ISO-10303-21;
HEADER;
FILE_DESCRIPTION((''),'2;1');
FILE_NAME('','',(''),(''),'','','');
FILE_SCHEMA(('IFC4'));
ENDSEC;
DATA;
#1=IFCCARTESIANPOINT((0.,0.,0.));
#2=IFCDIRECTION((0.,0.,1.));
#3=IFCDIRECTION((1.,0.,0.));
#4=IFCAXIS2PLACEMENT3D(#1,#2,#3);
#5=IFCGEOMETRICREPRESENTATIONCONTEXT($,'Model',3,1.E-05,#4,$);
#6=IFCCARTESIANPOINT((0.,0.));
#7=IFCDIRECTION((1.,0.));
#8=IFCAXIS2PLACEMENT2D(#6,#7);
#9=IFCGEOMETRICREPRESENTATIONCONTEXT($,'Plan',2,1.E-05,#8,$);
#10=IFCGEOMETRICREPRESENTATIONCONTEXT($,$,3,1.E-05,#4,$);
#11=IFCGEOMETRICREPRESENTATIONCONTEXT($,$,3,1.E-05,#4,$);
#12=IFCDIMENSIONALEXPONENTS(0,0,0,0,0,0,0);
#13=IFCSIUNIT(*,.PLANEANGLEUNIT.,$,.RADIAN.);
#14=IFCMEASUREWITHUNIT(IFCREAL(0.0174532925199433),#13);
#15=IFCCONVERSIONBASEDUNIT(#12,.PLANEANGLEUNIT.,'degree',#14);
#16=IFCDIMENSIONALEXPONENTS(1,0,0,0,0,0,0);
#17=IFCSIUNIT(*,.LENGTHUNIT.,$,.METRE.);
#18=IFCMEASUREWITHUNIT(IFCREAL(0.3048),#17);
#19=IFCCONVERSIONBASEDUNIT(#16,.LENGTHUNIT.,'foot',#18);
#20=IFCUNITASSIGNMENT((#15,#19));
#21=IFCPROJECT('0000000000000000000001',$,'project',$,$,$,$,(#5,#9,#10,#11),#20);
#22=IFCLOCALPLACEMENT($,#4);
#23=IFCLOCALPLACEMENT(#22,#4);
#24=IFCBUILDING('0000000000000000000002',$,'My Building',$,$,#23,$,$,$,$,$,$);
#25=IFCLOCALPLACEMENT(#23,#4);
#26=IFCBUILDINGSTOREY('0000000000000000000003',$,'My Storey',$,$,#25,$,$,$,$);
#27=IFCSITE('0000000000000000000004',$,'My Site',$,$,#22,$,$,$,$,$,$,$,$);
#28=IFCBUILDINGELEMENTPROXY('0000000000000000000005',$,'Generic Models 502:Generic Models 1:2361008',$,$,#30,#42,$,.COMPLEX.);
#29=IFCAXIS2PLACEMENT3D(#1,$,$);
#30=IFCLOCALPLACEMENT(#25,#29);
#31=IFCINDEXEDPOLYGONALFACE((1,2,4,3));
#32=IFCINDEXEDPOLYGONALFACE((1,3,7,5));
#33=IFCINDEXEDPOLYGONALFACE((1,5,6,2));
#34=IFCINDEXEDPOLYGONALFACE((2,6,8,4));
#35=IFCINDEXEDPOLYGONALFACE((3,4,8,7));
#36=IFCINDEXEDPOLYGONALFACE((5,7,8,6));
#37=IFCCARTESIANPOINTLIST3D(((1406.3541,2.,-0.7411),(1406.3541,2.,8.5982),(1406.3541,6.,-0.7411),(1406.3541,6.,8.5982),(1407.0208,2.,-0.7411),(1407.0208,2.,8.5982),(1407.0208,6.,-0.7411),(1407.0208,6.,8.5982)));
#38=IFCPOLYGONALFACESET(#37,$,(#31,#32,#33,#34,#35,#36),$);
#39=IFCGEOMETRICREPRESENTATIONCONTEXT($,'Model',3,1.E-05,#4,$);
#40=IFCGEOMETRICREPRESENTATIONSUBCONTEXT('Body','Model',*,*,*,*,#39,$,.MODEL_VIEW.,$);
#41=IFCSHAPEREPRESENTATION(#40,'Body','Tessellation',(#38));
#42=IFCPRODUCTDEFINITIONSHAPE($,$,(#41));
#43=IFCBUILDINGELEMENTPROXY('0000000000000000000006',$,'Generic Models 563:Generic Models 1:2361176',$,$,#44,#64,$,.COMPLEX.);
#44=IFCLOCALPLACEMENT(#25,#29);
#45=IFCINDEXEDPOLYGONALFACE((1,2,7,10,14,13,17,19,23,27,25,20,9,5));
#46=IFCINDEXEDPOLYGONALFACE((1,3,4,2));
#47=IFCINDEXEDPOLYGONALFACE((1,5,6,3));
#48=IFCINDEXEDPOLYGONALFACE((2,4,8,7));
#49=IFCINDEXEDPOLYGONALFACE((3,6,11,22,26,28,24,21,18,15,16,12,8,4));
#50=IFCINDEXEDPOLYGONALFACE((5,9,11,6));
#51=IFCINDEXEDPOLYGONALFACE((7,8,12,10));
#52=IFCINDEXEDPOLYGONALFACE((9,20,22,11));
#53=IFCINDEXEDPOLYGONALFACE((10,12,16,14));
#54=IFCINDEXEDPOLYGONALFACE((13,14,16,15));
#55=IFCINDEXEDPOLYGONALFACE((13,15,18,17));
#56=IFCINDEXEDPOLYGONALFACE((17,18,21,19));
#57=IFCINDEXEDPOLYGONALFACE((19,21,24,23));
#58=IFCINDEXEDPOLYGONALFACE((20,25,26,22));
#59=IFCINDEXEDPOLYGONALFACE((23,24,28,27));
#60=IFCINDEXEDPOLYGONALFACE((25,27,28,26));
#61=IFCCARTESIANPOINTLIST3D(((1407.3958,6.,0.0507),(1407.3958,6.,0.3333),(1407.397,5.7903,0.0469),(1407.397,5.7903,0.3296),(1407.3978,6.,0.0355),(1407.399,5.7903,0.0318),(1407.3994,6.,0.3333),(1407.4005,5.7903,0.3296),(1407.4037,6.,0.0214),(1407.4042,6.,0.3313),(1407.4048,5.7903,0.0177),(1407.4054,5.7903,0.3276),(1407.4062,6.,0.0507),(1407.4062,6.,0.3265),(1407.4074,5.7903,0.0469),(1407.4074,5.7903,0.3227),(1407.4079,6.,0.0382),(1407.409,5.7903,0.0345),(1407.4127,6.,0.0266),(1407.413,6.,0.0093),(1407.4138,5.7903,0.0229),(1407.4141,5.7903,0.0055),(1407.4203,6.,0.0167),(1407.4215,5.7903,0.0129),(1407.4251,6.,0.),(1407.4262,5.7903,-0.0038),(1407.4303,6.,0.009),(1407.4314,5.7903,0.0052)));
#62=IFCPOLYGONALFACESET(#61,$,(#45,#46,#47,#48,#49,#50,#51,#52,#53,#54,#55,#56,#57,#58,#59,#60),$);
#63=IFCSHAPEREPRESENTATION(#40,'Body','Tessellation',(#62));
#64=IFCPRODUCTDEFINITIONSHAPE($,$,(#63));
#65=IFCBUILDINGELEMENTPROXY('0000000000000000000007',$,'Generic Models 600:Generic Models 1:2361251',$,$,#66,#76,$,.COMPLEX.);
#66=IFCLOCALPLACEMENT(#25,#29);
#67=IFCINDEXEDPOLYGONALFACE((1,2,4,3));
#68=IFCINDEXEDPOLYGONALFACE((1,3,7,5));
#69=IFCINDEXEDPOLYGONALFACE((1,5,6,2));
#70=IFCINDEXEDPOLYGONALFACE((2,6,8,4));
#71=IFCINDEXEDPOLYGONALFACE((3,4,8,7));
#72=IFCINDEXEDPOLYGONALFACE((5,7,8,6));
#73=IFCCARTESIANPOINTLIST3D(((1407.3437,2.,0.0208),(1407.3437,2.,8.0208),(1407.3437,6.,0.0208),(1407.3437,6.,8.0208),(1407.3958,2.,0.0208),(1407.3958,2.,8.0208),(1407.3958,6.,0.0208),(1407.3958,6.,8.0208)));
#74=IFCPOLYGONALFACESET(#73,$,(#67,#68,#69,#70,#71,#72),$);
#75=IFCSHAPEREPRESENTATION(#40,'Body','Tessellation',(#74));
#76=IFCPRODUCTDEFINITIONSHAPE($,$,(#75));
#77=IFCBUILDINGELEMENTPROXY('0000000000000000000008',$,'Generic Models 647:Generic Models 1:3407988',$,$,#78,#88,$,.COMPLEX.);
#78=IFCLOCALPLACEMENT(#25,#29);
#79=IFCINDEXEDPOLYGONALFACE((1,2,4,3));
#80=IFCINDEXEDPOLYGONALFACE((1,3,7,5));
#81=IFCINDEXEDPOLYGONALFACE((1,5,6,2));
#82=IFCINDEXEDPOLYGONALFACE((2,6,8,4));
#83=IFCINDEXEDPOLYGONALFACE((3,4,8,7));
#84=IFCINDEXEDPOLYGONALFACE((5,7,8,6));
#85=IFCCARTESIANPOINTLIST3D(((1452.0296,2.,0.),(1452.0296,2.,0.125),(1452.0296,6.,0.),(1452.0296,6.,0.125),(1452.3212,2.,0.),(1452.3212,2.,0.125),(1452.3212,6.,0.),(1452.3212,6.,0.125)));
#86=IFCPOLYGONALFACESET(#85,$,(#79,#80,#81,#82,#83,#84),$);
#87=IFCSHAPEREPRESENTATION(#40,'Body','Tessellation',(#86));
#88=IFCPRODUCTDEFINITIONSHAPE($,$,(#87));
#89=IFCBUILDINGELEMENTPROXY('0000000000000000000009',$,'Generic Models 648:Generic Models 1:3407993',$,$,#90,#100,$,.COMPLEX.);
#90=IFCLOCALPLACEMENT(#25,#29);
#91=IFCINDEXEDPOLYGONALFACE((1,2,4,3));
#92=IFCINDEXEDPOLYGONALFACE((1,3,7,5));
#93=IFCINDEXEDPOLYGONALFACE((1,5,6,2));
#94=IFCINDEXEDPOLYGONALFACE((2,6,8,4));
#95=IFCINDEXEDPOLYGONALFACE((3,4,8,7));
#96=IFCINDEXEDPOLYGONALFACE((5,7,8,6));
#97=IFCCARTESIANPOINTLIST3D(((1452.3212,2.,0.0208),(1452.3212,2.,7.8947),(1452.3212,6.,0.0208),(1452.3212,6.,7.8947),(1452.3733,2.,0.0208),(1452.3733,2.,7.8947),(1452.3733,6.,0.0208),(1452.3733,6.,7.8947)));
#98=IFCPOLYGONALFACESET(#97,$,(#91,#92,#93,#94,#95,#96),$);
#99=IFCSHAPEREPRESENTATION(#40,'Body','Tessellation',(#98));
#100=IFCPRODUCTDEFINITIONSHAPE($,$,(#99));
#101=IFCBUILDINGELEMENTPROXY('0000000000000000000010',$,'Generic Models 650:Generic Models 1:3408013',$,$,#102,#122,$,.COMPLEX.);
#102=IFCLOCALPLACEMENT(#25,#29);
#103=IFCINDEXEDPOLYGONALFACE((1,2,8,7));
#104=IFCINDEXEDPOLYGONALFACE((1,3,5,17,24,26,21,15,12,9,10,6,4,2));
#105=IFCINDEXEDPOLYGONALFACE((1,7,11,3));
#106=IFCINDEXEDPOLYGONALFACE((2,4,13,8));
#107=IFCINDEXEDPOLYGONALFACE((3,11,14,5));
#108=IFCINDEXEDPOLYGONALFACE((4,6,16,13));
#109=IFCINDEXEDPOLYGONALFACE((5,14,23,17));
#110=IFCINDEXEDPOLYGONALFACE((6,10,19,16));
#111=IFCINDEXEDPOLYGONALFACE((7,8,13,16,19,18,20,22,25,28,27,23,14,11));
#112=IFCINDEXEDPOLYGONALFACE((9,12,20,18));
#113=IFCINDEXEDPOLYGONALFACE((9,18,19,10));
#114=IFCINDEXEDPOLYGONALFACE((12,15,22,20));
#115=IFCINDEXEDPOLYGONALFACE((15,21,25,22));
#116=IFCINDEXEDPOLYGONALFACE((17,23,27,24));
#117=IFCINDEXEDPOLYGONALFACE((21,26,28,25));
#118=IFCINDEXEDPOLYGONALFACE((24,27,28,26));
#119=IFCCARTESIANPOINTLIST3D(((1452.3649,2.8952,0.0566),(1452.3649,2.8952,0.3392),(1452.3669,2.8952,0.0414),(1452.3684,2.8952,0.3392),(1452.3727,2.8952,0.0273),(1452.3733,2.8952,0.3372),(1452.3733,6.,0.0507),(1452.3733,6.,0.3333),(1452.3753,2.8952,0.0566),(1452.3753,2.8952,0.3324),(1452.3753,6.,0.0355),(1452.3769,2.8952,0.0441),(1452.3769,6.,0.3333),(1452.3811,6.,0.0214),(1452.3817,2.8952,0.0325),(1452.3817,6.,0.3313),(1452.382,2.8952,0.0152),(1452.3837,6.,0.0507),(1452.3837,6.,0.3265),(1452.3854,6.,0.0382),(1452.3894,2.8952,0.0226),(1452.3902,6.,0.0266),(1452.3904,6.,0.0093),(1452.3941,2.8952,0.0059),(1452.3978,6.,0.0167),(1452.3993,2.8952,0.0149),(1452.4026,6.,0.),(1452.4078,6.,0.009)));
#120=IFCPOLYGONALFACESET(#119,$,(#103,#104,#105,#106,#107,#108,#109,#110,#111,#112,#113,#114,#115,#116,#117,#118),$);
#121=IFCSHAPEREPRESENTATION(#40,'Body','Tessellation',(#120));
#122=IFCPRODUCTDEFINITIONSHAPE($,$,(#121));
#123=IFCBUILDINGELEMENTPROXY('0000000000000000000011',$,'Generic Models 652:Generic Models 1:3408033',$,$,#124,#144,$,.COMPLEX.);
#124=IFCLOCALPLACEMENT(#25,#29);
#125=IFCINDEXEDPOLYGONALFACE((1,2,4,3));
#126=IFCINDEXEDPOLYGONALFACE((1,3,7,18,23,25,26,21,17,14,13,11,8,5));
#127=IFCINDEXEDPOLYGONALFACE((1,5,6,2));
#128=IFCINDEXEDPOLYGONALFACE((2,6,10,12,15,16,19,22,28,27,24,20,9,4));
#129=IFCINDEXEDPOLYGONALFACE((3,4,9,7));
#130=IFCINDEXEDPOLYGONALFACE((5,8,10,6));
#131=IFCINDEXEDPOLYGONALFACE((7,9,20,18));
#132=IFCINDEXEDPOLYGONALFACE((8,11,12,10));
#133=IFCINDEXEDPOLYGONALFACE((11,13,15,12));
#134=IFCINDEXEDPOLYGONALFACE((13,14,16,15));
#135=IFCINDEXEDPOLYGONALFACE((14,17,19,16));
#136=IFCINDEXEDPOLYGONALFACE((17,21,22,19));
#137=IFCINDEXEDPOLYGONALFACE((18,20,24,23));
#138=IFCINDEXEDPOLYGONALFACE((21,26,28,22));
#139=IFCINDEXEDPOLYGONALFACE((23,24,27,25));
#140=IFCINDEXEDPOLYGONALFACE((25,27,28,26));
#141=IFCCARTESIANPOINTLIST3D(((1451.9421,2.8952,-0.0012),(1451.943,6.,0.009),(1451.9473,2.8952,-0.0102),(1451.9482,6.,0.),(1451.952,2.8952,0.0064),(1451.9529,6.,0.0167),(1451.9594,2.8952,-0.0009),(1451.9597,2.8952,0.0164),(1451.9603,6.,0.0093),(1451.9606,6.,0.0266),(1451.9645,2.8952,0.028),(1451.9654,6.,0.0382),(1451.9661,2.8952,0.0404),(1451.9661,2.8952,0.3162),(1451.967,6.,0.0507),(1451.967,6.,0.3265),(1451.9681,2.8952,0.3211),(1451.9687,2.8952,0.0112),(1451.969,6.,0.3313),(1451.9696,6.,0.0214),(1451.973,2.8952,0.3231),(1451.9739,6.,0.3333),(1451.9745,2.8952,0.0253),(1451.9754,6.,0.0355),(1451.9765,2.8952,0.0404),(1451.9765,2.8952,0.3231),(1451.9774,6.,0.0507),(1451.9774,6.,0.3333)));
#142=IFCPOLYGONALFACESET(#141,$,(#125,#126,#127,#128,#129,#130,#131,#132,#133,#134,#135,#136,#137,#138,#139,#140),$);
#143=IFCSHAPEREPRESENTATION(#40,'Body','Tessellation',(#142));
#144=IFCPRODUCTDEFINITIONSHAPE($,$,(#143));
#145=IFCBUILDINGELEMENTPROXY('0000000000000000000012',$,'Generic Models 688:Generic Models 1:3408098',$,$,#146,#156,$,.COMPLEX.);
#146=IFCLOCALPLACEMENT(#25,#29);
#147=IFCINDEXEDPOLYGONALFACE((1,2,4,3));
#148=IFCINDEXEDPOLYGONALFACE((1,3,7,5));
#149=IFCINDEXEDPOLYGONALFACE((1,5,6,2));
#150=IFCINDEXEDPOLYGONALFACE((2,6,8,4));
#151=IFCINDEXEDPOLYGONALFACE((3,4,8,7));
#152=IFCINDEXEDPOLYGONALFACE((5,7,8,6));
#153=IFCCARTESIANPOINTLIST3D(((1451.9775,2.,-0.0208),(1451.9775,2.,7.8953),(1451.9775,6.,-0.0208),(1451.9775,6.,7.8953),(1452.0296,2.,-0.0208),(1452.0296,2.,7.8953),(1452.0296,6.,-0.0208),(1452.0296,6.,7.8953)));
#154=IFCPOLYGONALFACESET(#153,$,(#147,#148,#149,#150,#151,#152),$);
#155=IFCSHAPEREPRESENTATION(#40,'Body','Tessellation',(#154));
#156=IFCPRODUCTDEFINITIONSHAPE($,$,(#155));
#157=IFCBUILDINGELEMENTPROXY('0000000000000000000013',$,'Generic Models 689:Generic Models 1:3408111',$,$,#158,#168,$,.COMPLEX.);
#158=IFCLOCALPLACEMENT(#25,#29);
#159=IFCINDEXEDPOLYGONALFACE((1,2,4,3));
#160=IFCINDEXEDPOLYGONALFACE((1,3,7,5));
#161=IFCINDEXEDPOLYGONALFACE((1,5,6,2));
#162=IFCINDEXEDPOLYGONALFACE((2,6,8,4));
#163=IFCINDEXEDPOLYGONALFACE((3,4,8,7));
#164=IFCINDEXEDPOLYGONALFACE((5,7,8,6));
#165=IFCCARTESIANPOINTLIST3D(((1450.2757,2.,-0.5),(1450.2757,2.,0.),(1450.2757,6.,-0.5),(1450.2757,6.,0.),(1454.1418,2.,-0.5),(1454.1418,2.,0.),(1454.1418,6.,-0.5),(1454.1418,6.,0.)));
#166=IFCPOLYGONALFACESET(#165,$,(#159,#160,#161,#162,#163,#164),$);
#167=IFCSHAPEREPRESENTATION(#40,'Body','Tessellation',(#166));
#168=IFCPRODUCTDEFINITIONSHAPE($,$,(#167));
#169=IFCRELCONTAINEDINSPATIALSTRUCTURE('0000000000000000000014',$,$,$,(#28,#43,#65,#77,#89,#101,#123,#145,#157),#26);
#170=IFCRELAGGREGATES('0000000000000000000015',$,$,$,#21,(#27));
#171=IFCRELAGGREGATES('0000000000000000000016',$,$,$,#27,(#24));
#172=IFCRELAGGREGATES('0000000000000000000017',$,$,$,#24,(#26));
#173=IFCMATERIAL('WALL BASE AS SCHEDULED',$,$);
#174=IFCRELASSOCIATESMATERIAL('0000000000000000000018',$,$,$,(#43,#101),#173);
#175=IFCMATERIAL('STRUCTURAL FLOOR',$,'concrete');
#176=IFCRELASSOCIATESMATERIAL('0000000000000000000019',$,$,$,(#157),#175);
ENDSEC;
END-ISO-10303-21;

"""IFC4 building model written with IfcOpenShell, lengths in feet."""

from ifc_helpers import new_model, entity, si_unit, converted_unit, frame, origin_with_axes, origin_2d_with_axis, place, context, subcontext, project, spatial, polyline, line, indexed_curve, outline, extrude, material, element, save


model = new_model("IFC4")

# Units and contexts
model_context_1 = context("Model", 3, precision=1e-05, world=origin_with_axes())
plan_context = context("Plan", 2, precision=1e-05, world=origin_2d_with_axis())
model_context_2 = context("Model", 3, precision=1e-05, world=origin_with_axes())
context_of_model_1 = context(None, 3, precision=1e-05, world=origin_with_axes())
context_of_model_2 = context(None, 3, precision=1e-05, world=origin_with_axes())
body_context = subcontext(model_context_2, "Body", "Model", "MODEL_VIEW")
ifc_project = project(units=[converted_unit("PLANEANGLEUNIT", "degree", entity("IfcReal", 0.0174532925199433), si_unit("PLANEANGLEUNIT", "RADIAN"), dimensions=[0, 0, 0, 0, 0, 0, 0]), converted_unit("LENGTHUNIT", "foot", entity("IfcReal", 0.3048), si_unit("LENGTHUNIT", "METRE"), dimensions=[1, 0, 0, 0, 0, 0, 0])], contexts=[model_context_1, plan_context, context_of_model_1, context_of_model_2])

# Site, building, storey
site_placement = place(None, origin_with_axes())
site = spatial("IfcSite", under=ifc_project, at=site_placement, Name="My Site")
building_placement = place(site_placement, origin_with_axes())
building = spatial("IfcBuilding", under=site, at=building_placement, Name="My Building")
storey_placement = place(building_placement, origin_with_axes())
storey = spatial("IfcBuildingStorey", under=building, at=storey_placement, Name="My Storey")

# Building element proxies
proxy_1_placement = place(storey_placement, frame((1406.3541, 6.0, -0.7411), z_axis=(0.0, -1.0, 0.0), x_axis=(0.0, 0.0, 1.0)))
element("IfcBuildingElementProxy", 1, at=proxy_1_placement, inside=storey, Name="Generic Models 502:Generic Models 1:2361008", PredefinedType="COMPLEX", context=body_context, shape_type="SweptSolid", body=[
    extrude(outline(indexed_curve([(-0.3333, -4.6697), (0.3333, -4.6697), (0.3333, 4.6697), (-0.3333, 4.6697)], segments=[line(4, 1), line(1, 2), line(2, 3), line(3, 4)], self_intersect=False)), frame((4.6697, -0.3333, 0.0), z_axis=(0.0, 0.0, -1.0), x_axis=(0.0, 1.0, 0.0)), (0.0, 0.0, -1.0), 4.0),
])
ifc_material_1 = material(Name="WALL BASE AS SCHEDULED")
proxy_2_placement = place(storey_placement, frame((1407.3958, 6.0, 0.0), z_axis=(0.0, -1.0, 0.0), x_axis=(0.0, 0.0, 1.0)))
element("IfcBuildingElementProxy", 2, at=proxy_2_placement, inside=storey, material=ifc_material_1, Name="Generic Models 563:Generic Models 1:2361176", PredefinedType="COMPLEX", context=body_context, shape_type="SweptSolid", body=[
    extrude(outline(polyline([(0.0971, 0.0), (0.1059, -0.009), (0.1142, -0.0027), (0.1035, 0.0082), (0.0904, 0.016), (0.0756, 0.02), (0.0603, 0.0202), (-0.2202, -0.0144), (-0.2197, -0.0179), (-0.2172, -0.0225), (-0.2121, -0.0239), (0.0616, 0.0098), (0.0742, 0.0097), (0.0863, 0.0064), (0.0971, 0.0)])), frame((0.113, -0.0126, 0.0), z_axis=(0.0, 0.0, -1.0), x_axis=(-0.992503, -0.12222, 0.0)), (0.01852, -0.003236, -0.999823), 0.2098),
])
proxy_3_placement = place(storey_placement, frame((1407.3437, 6.0, 0.0208), z_axis=(0.0, -1.0, 0.0), x_axis=(0.0, 0.0, 1.0)))
element("IfcBuildingElementProxy", 3, at=proxy_3_placement, inside=storey, Name="Generic Models 600:Generic Models 1:2361251", PredefinedType="COMPLEX", context=body_context, shape_type="SweptSolid", body=[
    extrude(outline(polyline([(-4.0, -0.026), (4.0, -0.026), (4.0, 0.026), (-4.0, 0.026), (-4.0, -0.026)])), frame((4.0, -0.026, 0.0), z_axis=(0.0, 0.0, -1.0), x_axis=(1.0, 0.0, 0.0)), (0.0, 0.0, -1.0), 4.0),
])
proxy_4_placement = place(storey_placement, frame((1452.0296, 6.0, 0.0), z_axis=(0.0, -1.0, 0.0), x_axis=(0.0, 0.0, 1.0)))
element("IfcBuildingElementProxy", 4, at=proxy_4_placement, inside=storey, Name="Generic Models 647:Generic Models 1:3407988", PredefinedType="COMPLEX", context=body_context, shape_type="SweptSolid", body=[
    extrude(outline(polyline([(-0.0625, -0.1458), (0.0625, -0.1458), (0.0625, 0.1458), (-0.0625, 0.1458), (-0.0625, -0.1458)])), frame((0.0625, -0.1458, 0.0), z_axis=(0.0, 0.0, -1.0), x_axis=(1.0, 0.0, 0.0)), (0.0, 0.0, -1.0), 4.0),
])
proxy_5_placement = place(storey_placement, frame((1452.3212, 6.0, 0.0208), z_axis=(0.0, -1.0, 0.0), x_axis=(0.0, 0.0, 1.0)))
element("IfcBuildingElementProxy", 5, at=proxy_5_placement, inside=storey, Name="Generic Models 648:Generic Models 1:3407993", PredefinedType="COMPLEX", context=body_context, shape_type="SweptSolid", body=[
    extrude(outline(polyline([(-3.9369, -0.026), (3.9369, -0.026), (3.9369, 0.026), (-3.9369, 0.026), (-3.9369, -0.026)])), frame((3.9369, -0.026, 0.0), z_axis=(0.0, 0.0, -1.0), x_axis=(1.0, 0.0, 0.0)), (0.0, 0.0, -1.0), 4.0),
])
proxy_6_placement = place(storey_placement, frame((1452.3733, 6.0, 0.0), z_axis=(0.0, -1.0, 0.0), x_axis=(0.0, 0.0, 1.0)))
element("IfcBuildingElementProxy", 6, at=proxy_6_placement, inside=storey, material=ifc_material_1, Name="Generic Models 650:Generic Models 1:3408013", PredefinedType="COMPLEX", context=body_context, shape_type="SweptSolid", body=[
    extrude(outline(polyline([(0.2206, 0.0), (0.2204, 0.0036), (0.2182, 0.0083), (0.2132, 0.01), (-0.0621, -0.0058), (-0.0747, -0.0049), (-0.0865, -0.0007), (-0.0969, 0.0063), (-0.1051, 0.0158), (-0.1138, 0.0101), (-0.1038, -0.0014), (-0.0912, -0.01), (-0.0768, -0.0151), (-0.0615, -0.0162), (0.2206, 0.0)])), frame((0.113, -0.0126, 0.0), z_axis=(0.0, 0.0, -1.0), x_axis=(0.998358, 0.057286, 0.0)), (0.002054, -0.002598, -0.999995), 3.1048),
])
proxy_7_placement = place(storey_placement, frame((1451.943, 6.0, 0.0), z_axis=(0.0, -1.0, 0.0), x_axis=(0.0, 0.0, 1.0)))
element("IfcBuildingElementProxy", 7, at=proxy_7_placement, inside=storey, Name="Generic Models 652:Generic Models 1:3408033", PredefinedType="COMPLEX", context=body_context, shape_type="SweptSolid", body=[
    extrude(outline(polyline([(-0.0624, 0.0022), (0.2134, 0.0022), (0.2183, 0.0042), (0.2203, 0.0091), (0.2203, 0.0126), (-0.0624, 0.0126), (-0.0775, 0.0106), (-0.0916, 0.0048), (-0.1037, -0.0045), (-0.113, -0.0166), (-0.104, -0.0218), (-0.0964, -0.0119), (-0.0864, -0.0042), (-0.0748, 0.0006), (-0.0624, 0.0022)])), frame((0.113, -0.0218, 0.0), z_axis=(0.0, 0.0, -1.0), x_axis=(1.0, 0.0, 0.0)), (-0.003299, -0.000291, -0.999995), 3.1048),
])
proxy_8_placement = place(storey_placement, frame((1451.9775, 6.0, -0.0208), z_axis=(0.0, -1.0, 0.0), x_axis=(0.0, 0.0, 1.0)))
element("IfcBuildingElementProxy", 8, at=proxy_8_placement, inside=storey, Name="Generic Models 688:Generic Models 1:3408098", PredefinedType="COMPLEX", context=body_context, shape_type="SweptSolid", body=[
    extrude(outline(polyline([(-3.9581, -0.026), (3.9581, -0.026), (3.9581, 0.026), (-3.9581, 0.026), (-3.9581, -0.026)])), frame((3.9581, -0.026, 0.0), z_axis=(0.0, 0.0, -1.0), x_axis=(1.0, 0.0, 0.0)), (0.0, 0.0, -1.0), 4.0),
])
ifc_material_2 = material(Name="STRUCTURAL FLOOR", Category="concrete")
proxy_9_placement = place(storey_placement, frame((1450.2757, 6.0, -0.5), z_axis=(0.0, -1.0, 0.0), x_axis=(0.0, 0.0, 1.0)))
element("IfcBuildingElementProxy", 9, at=proxy_9_placement, inside=storey, material=ifc_material_2, Name="Generic Models 689:Generic Models 1:3408111", PredefinedType="COMPLEX", context=body_context, shape_type="SweptSolid", body=[
    extrude(outline(polyline([(-0.25, -1.9331), (0.25, -1.9331), (0.25, 1.9331), (-0.25, 1.9331), (-0.25, -1.9331)])), frame((0.25, -1.9331, 0.0), z_axis=(0.0, 0.0, -1.0), x_axis=(1.0, 0.0, 0.0)), (0.0, 0.0, -1.0), 4.0),
])

save(model, "model.ifc")
